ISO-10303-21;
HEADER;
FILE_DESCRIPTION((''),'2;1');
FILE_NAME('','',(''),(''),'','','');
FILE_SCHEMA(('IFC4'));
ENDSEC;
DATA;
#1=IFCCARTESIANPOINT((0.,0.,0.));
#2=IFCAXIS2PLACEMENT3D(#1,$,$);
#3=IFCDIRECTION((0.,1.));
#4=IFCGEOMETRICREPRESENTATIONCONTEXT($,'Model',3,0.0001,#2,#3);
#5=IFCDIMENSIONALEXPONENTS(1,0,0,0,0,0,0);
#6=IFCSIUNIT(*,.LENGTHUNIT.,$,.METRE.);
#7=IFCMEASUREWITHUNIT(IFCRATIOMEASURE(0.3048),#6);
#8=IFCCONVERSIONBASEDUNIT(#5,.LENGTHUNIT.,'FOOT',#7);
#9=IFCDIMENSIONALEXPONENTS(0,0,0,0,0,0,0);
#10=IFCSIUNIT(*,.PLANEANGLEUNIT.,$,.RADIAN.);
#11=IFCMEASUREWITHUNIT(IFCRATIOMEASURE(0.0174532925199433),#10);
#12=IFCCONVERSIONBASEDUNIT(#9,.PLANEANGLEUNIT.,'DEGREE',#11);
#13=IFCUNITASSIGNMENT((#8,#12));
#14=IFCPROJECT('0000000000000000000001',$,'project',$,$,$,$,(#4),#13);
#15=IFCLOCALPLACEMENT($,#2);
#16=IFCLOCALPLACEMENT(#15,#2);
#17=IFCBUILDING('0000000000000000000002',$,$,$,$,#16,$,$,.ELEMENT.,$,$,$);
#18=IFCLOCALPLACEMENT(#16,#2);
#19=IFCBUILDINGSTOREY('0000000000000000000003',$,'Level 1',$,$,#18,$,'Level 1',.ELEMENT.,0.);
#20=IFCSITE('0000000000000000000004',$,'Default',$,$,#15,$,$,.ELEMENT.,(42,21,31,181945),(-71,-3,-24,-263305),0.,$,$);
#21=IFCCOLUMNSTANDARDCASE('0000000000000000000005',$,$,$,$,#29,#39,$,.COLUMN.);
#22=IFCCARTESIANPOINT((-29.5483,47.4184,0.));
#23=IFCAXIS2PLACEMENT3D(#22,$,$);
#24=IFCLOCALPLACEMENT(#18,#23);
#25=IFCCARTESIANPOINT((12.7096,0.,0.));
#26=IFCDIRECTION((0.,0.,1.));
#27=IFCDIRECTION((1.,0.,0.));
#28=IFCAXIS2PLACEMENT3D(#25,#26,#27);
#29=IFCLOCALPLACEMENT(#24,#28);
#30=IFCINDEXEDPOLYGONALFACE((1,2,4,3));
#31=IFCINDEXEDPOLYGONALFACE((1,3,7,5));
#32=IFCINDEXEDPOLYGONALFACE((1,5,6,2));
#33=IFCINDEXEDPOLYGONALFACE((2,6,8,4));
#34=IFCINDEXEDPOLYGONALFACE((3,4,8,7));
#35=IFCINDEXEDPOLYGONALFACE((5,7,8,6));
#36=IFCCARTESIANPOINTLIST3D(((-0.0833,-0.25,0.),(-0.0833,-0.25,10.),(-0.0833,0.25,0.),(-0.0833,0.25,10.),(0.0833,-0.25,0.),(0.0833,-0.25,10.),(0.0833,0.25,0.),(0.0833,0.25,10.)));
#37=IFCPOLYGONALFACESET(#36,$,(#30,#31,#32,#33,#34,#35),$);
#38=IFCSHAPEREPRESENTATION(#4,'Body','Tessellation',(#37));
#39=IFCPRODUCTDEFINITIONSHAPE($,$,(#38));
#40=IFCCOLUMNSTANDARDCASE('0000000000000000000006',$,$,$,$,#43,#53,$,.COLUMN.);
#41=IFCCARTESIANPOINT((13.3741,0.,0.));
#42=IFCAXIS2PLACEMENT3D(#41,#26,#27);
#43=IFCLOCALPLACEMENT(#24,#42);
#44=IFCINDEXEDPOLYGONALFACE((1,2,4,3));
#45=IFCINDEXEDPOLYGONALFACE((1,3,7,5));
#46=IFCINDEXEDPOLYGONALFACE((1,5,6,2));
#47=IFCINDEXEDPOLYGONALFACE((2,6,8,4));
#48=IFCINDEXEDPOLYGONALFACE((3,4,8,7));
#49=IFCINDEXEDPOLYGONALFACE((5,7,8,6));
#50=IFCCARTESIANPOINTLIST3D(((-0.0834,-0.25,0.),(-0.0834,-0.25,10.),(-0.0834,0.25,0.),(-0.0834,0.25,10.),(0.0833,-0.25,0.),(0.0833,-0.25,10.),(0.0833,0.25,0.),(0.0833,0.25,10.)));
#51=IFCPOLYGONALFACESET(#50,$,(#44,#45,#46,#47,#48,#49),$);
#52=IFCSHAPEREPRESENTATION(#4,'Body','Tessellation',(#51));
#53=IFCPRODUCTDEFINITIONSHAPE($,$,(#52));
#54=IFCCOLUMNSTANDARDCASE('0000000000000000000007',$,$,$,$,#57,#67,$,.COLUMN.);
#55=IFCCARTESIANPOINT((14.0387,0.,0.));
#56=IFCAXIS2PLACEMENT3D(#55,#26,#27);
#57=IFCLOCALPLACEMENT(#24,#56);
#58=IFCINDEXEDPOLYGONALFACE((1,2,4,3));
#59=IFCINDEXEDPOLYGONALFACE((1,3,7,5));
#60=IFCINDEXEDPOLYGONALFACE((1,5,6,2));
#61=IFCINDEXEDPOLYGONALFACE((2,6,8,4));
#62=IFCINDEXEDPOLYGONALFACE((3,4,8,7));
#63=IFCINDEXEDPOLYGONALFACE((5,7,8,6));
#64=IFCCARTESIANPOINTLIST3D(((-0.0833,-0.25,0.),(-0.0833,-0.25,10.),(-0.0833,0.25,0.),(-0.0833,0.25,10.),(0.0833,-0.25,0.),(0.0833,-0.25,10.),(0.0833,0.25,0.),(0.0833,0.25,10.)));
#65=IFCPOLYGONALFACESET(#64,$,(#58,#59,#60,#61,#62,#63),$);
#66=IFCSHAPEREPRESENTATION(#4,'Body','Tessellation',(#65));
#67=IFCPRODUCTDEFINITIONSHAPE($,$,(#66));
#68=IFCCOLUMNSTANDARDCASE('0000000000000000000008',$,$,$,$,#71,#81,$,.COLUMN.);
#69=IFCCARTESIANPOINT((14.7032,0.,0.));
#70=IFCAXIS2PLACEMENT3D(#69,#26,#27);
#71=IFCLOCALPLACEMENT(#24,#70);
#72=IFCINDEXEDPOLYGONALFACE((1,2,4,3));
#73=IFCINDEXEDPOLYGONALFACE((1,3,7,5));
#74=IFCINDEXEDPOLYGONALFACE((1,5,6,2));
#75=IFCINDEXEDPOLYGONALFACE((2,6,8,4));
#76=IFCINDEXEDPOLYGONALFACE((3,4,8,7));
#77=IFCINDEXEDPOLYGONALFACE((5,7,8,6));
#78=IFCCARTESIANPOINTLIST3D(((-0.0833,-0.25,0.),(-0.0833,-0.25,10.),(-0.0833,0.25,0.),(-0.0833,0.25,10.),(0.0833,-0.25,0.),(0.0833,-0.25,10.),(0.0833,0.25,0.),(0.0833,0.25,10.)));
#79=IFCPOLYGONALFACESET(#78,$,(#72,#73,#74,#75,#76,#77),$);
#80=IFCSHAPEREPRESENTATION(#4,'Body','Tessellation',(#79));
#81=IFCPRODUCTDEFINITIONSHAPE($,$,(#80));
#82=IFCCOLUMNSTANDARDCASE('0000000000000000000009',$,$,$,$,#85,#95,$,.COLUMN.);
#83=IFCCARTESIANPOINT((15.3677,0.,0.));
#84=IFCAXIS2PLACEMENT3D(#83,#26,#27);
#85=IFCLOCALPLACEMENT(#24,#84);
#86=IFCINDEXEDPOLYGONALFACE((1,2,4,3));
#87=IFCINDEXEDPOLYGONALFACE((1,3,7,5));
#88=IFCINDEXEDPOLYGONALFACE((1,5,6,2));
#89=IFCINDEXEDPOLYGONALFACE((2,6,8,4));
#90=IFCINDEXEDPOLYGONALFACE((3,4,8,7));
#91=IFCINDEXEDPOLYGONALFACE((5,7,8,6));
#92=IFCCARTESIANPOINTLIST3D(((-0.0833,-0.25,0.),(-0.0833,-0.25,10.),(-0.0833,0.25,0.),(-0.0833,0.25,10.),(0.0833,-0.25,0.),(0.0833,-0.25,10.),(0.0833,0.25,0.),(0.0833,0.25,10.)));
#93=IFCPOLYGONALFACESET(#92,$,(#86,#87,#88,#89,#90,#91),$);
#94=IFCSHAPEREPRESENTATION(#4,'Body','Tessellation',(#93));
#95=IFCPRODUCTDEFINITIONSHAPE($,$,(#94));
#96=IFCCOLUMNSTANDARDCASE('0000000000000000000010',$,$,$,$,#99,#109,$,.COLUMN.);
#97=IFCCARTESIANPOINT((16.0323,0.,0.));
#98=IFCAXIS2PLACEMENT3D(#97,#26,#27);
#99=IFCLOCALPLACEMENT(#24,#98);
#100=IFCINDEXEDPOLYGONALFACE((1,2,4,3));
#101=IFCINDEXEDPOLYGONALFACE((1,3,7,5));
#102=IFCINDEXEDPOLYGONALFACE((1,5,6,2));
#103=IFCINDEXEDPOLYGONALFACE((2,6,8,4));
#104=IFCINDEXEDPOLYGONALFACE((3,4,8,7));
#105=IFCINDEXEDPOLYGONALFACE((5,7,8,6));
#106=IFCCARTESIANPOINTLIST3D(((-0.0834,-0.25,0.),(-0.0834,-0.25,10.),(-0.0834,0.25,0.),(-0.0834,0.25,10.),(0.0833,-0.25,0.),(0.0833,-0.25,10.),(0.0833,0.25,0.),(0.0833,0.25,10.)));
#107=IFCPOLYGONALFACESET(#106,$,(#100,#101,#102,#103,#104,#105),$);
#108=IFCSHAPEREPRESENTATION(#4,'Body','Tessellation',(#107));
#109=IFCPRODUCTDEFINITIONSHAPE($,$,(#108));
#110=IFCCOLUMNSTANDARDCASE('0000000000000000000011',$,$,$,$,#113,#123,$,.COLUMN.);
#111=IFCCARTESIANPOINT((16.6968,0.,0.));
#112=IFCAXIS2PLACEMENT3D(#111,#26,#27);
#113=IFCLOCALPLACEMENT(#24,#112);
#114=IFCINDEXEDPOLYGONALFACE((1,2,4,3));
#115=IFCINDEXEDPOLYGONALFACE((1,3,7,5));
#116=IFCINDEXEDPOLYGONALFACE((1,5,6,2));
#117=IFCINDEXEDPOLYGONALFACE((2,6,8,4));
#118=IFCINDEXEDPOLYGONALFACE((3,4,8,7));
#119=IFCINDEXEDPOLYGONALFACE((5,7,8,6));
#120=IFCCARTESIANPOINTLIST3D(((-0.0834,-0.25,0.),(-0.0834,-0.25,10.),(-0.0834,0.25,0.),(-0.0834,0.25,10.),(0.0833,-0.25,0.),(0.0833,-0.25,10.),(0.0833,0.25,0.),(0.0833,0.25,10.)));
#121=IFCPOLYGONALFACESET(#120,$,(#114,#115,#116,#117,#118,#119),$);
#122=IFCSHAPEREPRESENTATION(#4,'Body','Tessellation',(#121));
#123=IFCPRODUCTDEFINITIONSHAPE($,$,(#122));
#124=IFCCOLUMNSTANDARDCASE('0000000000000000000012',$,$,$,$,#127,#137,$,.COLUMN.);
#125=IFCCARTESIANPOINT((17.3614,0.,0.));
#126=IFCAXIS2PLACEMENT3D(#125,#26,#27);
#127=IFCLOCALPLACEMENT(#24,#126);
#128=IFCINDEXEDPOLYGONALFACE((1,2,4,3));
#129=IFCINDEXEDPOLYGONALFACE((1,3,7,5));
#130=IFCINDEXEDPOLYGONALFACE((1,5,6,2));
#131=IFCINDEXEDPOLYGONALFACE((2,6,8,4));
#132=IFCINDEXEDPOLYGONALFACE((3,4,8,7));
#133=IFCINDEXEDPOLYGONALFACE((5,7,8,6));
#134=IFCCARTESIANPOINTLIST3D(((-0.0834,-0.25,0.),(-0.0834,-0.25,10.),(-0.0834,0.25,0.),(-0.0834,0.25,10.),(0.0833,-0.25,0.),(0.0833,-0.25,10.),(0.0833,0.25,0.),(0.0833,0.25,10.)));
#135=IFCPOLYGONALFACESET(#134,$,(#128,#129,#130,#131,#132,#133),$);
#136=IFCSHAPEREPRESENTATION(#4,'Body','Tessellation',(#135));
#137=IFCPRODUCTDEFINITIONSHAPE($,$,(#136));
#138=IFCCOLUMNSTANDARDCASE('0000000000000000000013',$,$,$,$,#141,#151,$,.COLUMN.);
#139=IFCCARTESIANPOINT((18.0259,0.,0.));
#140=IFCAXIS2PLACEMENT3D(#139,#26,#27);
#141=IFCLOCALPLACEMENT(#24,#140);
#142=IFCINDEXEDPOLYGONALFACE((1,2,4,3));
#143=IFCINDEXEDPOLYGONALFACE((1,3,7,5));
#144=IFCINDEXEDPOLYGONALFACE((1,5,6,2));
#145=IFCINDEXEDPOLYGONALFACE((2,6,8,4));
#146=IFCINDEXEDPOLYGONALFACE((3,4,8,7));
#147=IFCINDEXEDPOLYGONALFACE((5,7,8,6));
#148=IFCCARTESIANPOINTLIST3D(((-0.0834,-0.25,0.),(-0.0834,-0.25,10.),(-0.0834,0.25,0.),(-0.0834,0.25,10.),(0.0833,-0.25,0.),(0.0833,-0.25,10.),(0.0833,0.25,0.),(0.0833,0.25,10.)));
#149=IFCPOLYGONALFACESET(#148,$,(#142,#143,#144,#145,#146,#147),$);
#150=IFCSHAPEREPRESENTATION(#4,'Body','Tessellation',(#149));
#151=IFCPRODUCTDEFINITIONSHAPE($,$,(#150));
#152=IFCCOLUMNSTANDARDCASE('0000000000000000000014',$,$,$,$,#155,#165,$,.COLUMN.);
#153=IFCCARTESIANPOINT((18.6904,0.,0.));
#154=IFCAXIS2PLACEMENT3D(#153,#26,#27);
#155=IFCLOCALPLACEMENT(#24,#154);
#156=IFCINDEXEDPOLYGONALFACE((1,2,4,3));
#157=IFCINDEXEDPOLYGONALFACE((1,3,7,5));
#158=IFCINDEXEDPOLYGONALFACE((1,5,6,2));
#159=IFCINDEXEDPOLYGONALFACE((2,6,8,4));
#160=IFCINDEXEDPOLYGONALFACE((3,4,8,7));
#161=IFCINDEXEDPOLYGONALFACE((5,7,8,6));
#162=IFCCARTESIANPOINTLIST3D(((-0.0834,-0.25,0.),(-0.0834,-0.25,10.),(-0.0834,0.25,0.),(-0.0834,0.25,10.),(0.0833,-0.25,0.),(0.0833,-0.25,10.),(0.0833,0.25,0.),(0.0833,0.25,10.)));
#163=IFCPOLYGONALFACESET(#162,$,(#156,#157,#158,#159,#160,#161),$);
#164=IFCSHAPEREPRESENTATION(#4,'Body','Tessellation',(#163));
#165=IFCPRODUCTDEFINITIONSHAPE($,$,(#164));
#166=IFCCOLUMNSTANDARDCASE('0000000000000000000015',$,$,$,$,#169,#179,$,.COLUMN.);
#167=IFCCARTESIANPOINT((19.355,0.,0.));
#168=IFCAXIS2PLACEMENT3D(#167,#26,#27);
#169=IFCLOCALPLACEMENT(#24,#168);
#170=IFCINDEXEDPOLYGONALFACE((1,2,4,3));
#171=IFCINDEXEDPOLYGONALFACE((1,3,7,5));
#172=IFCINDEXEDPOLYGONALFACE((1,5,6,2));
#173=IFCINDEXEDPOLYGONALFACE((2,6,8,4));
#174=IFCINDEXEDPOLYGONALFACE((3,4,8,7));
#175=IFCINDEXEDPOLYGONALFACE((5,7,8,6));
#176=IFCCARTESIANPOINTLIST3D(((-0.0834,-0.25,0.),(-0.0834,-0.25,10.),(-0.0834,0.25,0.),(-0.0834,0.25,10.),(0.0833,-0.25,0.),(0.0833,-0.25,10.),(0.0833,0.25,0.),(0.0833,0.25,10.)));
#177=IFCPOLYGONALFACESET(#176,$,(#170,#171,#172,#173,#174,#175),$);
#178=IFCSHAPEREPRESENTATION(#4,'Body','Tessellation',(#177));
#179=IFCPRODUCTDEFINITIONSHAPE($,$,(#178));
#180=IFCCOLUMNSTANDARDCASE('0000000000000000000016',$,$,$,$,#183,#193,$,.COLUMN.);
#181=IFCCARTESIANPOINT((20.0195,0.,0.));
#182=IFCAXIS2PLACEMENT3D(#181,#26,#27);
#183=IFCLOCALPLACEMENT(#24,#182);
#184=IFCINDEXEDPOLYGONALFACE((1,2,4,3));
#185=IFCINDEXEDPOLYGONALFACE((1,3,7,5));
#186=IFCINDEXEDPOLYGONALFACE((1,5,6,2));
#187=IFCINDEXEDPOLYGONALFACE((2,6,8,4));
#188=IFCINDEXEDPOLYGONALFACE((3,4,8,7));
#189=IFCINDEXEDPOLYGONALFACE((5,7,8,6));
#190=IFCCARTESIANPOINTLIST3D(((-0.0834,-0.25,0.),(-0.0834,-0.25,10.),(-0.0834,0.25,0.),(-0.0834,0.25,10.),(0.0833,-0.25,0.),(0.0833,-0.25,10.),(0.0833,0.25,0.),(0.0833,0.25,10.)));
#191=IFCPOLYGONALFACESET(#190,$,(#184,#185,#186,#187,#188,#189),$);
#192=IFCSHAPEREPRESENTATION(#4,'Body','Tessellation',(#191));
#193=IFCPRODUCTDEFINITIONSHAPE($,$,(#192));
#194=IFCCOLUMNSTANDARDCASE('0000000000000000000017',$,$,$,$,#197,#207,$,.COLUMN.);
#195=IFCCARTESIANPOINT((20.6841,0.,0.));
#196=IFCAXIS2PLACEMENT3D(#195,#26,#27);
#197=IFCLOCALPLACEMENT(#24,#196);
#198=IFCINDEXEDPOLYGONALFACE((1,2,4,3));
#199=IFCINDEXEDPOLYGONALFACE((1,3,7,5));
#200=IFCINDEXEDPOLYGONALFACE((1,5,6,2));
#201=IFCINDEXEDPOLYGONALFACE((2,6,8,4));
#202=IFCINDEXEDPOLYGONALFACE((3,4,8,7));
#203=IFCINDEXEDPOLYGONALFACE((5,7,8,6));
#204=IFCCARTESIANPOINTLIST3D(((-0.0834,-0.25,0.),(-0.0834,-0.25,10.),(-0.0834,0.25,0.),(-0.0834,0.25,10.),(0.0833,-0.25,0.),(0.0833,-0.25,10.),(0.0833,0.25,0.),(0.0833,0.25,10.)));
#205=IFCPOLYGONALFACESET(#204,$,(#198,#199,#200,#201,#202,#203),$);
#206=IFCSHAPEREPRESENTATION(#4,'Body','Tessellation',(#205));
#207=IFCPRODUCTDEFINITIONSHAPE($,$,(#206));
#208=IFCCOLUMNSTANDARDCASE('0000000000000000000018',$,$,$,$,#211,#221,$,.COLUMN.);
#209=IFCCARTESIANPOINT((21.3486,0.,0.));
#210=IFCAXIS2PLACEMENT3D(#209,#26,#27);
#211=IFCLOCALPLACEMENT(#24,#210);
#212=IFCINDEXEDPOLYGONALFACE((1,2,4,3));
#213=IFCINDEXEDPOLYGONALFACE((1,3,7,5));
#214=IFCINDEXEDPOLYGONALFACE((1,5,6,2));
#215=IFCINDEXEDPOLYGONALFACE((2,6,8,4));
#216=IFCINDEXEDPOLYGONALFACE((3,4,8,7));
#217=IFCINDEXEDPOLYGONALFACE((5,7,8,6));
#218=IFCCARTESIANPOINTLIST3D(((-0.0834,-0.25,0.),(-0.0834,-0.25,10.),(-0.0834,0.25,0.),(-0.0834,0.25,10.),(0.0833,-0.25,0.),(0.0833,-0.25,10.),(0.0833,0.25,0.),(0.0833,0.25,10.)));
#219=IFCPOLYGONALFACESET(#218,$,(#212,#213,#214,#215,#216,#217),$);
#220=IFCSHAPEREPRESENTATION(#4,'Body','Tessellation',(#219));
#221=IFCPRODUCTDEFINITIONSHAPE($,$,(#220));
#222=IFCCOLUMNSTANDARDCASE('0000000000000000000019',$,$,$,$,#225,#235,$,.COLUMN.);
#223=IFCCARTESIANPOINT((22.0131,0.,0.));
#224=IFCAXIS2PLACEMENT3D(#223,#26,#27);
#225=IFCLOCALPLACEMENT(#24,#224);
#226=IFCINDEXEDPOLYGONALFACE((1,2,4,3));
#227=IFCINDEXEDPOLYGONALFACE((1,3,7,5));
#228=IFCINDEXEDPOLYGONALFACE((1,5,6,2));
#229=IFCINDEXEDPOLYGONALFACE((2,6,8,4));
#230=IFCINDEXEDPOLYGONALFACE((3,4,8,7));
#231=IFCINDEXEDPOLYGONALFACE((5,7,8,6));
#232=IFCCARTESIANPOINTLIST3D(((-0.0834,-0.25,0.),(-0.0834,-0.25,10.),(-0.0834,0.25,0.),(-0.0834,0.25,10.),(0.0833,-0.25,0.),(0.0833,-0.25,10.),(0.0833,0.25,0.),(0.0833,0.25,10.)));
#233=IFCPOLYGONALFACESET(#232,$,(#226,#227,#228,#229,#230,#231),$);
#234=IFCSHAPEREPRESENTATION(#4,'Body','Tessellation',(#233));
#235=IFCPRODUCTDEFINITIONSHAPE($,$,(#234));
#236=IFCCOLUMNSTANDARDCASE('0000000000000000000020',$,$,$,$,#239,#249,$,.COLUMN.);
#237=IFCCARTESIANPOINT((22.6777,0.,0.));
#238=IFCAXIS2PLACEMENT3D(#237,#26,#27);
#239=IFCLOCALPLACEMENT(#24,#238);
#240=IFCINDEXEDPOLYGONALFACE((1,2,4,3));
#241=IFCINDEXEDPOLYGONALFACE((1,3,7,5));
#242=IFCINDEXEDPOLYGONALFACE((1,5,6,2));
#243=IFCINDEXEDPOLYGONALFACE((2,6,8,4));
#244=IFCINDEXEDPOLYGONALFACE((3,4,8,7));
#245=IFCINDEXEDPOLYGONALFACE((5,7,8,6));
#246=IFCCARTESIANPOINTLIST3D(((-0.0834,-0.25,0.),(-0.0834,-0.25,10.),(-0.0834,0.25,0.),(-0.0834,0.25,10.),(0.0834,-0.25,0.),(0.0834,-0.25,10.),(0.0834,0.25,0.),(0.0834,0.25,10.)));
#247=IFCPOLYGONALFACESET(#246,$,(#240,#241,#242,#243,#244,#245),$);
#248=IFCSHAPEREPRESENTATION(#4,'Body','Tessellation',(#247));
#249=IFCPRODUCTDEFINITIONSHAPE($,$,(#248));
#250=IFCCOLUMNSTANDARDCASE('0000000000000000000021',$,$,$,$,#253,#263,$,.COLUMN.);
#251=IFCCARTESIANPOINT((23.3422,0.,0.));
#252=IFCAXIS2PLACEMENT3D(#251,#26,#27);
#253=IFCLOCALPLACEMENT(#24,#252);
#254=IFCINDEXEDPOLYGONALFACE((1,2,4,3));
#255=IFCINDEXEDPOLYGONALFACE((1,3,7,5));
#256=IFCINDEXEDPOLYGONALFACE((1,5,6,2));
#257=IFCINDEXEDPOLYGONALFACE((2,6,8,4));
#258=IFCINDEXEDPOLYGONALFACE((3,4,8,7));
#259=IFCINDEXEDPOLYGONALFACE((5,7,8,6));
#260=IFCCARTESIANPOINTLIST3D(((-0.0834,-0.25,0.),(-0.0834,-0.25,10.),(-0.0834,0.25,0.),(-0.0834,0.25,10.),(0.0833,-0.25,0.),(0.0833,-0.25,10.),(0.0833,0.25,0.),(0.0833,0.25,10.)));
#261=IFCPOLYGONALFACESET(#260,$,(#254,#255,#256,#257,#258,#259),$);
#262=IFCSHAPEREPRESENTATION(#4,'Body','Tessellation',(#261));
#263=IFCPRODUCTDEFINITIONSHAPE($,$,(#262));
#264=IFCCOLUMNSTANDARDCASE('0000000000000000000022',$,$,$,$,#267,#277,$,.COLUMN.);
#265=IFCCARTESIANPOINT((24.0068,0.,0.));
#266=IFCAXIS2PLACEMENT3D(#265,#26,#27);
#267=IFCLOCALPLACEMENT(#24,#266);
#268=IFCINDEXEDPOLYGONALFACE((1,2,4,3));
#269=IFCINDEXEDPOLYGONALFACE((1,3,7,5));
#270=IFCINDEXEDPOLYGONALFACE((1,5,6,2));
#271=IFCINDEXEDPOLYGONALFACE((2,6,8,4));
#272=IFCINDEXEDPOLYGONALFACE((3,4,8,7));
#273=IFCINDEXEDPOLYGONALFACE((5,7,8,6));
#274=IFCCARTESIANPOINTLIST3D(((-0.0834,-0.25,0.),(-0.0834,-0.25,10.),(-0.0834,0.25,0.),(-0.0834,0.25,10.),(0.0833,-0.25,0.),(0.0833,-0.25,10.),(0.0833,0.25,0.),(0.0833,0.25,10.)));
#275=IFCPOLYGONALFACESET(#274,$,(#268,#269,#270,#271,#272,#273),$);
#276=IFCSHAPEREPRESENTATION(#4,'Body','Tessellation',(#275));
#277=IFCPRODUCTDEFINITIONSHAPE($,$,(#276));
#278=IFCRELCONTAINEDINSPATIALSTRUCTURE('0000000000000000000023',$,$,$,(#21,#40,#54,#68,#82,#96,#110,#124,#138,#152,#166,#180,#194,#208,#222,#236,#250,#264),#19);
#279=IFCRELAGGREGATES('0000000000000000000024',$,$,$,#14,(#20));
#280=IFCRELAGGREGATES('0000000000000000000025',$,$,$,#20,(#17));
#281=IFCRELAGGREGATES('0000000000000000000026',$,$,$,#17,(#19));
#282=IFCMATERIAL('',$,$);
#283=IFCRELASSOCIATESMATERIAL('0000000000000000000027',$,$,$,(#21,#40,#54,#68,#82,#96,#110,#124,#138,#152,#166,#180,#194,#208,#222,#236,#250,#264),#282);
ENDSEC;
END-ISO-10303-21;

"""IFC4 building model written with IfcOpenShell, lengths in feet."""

from ifc_helpers import new_model, entity, si_unit, converted_unit, direction, frame, origin, place, context, project, spatial, rectangle, extrude, material, element, save


model = new_model("IFC4")

# Units and contexts
model_context = context("Model", 3, precision=0.0001, world=origin(), true_north=direction((0.0, 1.0)))
ifc_project = project(units=[converted_unit("LENGTHUNIT", "FOOT", entity("IfcRatioMeasure", 0.3048), si_unit("LENGTHUNIT", "METRE"), dimensions=[1, 0, 0, 0, 0, 0, 0]), converted_unit("PLANEANGLEUNIT", "DEGREE", entity("IfcRatioMeasure", 0.0174532925199433), si_unit("PLANEANGLEUNIT", "RADIAN"), dimensions=[0, 0, 0, 0, 0, 0, 0])], contexts=[model_context])

# Site, building, storey
site_placement = place(None, origin())
site = spatial("IfcSite", under=ifc_project, at=site_placement, Name="Default", CompositionType="ELEMENT", RefLatitude=(42, 21, 31, 181945), RefLongitude=(-71, -3, -24, -263305), RefElevation=0.0)
building_placement = place(site_placement, origin())
building = spatial("IfcBuilding", under=site, at=building_placement, CompositionType="ELEMENT")
storey_placement = place(building_placement, origin())
storey = spatial("IfcBuildingStorey", under=building, at=storey_placement, Name="Level 1", LongName="Level 1", CompositionType="ELEMENT", Elevation=0.0)

# Columns
ifc_material = material(Name="")
placement = place(storey_placement, frame((-29.5483, 47.4184, 0.0)))
for number, where, z_axis, x_axis in (
    (1, (12.7096, 0.0, 0.0), (0.0, 0.0, 1.0), (1.0, 0.0, 0.0)),
    (2, (13.3741, 0.0, 0.0), (0.0, 0.0, 1.0), (1.0, 0.0, 0.0)),
    (3, (14.0387, 0.0, 0.0), (0.0, 0.0, 1.0), (1.0, 0.0, 0.0)),
    (4, (14.7032, 0.0, 0.0), (0.0, 0.0, 1.0), (1.0, 0.0, 0.0)),
    (5, (15.3677, 0.0, 0.0), (0.0, 0.0, 1.0), (1.0, 0.0, 0.0)),
    (6, (16.0323, 0.0, 0.0), (0.0, 0.0, 1.0), (1.0, 0.0, 0.0)),
    (7, (16.6968, 0.0, 0.0), (0.0, 0.0, 1.0), (1.0, 0.0, 0.0)),
    (8, (17.3614, 0.0, 0.0), (0.0, 0.0, 1.0), (1.0, 0.0, 0.0)),
    (9, (18.0259, 0.0, 0.0), (0.0, 0.0, 1.0), (1.0, 0.0, 0.0)),
    (10, (18.6904, 0.0, 0.0), (0.0, 0.0, 1.0), (1.0, 0.0, 0.0)),
    (11, (19.355, 0.0, 0.0), (0.0, 0.0, 1.0), (1.0, 0.0, 0.0)),
    (12, (20.0195, 0.0, 0.0), (0.0, 0.0, 1.0), (1.0, 0.0, 0.0)),
    (13, (20.6841, 0.0, 0.0), (0.0, 0.0, 1.0), (1.0, 0.0, 0.0)),
    (14, (21.3486, 0.0, 0.0), (0.0, 0.0, 1.0), (1.0, 0.0, 0.0)),
    (15, (22.0131, 0.0, 0.0), (0.0, 0.0, 1.0), (1.0, 0.0, 0.0)),
    (16, (22.6777, 0.0, 0.0), (0.0, 0.0, 1.0), (1.0, 0.0, 0.0)),
    (17, (23.3422, 0.0, 0.0), (0.0, 0.0, 1.0), (1.0, 0.0, 0.0)),
    (18, (24.0068, 0.0, 0.0), (0.0, 0.0, 1.0), (1.0, 0.0, 0.0)),
):
    element("IfcColumnStandardCase", number, at=place(placement, frame(where, z_axis=z_axis, x_axis=x_axis)), inside=storey, material=ifc_material, PredefinedType="COLUMN", context=model_context, shape_type="SweptSolid", body=[
        extrude(rectangle(XDim=0.1667, YDim=0.5), origin(), (0.0, 0.0, 1.0), 10.0),
    ])

save(model, "model.ifc")
